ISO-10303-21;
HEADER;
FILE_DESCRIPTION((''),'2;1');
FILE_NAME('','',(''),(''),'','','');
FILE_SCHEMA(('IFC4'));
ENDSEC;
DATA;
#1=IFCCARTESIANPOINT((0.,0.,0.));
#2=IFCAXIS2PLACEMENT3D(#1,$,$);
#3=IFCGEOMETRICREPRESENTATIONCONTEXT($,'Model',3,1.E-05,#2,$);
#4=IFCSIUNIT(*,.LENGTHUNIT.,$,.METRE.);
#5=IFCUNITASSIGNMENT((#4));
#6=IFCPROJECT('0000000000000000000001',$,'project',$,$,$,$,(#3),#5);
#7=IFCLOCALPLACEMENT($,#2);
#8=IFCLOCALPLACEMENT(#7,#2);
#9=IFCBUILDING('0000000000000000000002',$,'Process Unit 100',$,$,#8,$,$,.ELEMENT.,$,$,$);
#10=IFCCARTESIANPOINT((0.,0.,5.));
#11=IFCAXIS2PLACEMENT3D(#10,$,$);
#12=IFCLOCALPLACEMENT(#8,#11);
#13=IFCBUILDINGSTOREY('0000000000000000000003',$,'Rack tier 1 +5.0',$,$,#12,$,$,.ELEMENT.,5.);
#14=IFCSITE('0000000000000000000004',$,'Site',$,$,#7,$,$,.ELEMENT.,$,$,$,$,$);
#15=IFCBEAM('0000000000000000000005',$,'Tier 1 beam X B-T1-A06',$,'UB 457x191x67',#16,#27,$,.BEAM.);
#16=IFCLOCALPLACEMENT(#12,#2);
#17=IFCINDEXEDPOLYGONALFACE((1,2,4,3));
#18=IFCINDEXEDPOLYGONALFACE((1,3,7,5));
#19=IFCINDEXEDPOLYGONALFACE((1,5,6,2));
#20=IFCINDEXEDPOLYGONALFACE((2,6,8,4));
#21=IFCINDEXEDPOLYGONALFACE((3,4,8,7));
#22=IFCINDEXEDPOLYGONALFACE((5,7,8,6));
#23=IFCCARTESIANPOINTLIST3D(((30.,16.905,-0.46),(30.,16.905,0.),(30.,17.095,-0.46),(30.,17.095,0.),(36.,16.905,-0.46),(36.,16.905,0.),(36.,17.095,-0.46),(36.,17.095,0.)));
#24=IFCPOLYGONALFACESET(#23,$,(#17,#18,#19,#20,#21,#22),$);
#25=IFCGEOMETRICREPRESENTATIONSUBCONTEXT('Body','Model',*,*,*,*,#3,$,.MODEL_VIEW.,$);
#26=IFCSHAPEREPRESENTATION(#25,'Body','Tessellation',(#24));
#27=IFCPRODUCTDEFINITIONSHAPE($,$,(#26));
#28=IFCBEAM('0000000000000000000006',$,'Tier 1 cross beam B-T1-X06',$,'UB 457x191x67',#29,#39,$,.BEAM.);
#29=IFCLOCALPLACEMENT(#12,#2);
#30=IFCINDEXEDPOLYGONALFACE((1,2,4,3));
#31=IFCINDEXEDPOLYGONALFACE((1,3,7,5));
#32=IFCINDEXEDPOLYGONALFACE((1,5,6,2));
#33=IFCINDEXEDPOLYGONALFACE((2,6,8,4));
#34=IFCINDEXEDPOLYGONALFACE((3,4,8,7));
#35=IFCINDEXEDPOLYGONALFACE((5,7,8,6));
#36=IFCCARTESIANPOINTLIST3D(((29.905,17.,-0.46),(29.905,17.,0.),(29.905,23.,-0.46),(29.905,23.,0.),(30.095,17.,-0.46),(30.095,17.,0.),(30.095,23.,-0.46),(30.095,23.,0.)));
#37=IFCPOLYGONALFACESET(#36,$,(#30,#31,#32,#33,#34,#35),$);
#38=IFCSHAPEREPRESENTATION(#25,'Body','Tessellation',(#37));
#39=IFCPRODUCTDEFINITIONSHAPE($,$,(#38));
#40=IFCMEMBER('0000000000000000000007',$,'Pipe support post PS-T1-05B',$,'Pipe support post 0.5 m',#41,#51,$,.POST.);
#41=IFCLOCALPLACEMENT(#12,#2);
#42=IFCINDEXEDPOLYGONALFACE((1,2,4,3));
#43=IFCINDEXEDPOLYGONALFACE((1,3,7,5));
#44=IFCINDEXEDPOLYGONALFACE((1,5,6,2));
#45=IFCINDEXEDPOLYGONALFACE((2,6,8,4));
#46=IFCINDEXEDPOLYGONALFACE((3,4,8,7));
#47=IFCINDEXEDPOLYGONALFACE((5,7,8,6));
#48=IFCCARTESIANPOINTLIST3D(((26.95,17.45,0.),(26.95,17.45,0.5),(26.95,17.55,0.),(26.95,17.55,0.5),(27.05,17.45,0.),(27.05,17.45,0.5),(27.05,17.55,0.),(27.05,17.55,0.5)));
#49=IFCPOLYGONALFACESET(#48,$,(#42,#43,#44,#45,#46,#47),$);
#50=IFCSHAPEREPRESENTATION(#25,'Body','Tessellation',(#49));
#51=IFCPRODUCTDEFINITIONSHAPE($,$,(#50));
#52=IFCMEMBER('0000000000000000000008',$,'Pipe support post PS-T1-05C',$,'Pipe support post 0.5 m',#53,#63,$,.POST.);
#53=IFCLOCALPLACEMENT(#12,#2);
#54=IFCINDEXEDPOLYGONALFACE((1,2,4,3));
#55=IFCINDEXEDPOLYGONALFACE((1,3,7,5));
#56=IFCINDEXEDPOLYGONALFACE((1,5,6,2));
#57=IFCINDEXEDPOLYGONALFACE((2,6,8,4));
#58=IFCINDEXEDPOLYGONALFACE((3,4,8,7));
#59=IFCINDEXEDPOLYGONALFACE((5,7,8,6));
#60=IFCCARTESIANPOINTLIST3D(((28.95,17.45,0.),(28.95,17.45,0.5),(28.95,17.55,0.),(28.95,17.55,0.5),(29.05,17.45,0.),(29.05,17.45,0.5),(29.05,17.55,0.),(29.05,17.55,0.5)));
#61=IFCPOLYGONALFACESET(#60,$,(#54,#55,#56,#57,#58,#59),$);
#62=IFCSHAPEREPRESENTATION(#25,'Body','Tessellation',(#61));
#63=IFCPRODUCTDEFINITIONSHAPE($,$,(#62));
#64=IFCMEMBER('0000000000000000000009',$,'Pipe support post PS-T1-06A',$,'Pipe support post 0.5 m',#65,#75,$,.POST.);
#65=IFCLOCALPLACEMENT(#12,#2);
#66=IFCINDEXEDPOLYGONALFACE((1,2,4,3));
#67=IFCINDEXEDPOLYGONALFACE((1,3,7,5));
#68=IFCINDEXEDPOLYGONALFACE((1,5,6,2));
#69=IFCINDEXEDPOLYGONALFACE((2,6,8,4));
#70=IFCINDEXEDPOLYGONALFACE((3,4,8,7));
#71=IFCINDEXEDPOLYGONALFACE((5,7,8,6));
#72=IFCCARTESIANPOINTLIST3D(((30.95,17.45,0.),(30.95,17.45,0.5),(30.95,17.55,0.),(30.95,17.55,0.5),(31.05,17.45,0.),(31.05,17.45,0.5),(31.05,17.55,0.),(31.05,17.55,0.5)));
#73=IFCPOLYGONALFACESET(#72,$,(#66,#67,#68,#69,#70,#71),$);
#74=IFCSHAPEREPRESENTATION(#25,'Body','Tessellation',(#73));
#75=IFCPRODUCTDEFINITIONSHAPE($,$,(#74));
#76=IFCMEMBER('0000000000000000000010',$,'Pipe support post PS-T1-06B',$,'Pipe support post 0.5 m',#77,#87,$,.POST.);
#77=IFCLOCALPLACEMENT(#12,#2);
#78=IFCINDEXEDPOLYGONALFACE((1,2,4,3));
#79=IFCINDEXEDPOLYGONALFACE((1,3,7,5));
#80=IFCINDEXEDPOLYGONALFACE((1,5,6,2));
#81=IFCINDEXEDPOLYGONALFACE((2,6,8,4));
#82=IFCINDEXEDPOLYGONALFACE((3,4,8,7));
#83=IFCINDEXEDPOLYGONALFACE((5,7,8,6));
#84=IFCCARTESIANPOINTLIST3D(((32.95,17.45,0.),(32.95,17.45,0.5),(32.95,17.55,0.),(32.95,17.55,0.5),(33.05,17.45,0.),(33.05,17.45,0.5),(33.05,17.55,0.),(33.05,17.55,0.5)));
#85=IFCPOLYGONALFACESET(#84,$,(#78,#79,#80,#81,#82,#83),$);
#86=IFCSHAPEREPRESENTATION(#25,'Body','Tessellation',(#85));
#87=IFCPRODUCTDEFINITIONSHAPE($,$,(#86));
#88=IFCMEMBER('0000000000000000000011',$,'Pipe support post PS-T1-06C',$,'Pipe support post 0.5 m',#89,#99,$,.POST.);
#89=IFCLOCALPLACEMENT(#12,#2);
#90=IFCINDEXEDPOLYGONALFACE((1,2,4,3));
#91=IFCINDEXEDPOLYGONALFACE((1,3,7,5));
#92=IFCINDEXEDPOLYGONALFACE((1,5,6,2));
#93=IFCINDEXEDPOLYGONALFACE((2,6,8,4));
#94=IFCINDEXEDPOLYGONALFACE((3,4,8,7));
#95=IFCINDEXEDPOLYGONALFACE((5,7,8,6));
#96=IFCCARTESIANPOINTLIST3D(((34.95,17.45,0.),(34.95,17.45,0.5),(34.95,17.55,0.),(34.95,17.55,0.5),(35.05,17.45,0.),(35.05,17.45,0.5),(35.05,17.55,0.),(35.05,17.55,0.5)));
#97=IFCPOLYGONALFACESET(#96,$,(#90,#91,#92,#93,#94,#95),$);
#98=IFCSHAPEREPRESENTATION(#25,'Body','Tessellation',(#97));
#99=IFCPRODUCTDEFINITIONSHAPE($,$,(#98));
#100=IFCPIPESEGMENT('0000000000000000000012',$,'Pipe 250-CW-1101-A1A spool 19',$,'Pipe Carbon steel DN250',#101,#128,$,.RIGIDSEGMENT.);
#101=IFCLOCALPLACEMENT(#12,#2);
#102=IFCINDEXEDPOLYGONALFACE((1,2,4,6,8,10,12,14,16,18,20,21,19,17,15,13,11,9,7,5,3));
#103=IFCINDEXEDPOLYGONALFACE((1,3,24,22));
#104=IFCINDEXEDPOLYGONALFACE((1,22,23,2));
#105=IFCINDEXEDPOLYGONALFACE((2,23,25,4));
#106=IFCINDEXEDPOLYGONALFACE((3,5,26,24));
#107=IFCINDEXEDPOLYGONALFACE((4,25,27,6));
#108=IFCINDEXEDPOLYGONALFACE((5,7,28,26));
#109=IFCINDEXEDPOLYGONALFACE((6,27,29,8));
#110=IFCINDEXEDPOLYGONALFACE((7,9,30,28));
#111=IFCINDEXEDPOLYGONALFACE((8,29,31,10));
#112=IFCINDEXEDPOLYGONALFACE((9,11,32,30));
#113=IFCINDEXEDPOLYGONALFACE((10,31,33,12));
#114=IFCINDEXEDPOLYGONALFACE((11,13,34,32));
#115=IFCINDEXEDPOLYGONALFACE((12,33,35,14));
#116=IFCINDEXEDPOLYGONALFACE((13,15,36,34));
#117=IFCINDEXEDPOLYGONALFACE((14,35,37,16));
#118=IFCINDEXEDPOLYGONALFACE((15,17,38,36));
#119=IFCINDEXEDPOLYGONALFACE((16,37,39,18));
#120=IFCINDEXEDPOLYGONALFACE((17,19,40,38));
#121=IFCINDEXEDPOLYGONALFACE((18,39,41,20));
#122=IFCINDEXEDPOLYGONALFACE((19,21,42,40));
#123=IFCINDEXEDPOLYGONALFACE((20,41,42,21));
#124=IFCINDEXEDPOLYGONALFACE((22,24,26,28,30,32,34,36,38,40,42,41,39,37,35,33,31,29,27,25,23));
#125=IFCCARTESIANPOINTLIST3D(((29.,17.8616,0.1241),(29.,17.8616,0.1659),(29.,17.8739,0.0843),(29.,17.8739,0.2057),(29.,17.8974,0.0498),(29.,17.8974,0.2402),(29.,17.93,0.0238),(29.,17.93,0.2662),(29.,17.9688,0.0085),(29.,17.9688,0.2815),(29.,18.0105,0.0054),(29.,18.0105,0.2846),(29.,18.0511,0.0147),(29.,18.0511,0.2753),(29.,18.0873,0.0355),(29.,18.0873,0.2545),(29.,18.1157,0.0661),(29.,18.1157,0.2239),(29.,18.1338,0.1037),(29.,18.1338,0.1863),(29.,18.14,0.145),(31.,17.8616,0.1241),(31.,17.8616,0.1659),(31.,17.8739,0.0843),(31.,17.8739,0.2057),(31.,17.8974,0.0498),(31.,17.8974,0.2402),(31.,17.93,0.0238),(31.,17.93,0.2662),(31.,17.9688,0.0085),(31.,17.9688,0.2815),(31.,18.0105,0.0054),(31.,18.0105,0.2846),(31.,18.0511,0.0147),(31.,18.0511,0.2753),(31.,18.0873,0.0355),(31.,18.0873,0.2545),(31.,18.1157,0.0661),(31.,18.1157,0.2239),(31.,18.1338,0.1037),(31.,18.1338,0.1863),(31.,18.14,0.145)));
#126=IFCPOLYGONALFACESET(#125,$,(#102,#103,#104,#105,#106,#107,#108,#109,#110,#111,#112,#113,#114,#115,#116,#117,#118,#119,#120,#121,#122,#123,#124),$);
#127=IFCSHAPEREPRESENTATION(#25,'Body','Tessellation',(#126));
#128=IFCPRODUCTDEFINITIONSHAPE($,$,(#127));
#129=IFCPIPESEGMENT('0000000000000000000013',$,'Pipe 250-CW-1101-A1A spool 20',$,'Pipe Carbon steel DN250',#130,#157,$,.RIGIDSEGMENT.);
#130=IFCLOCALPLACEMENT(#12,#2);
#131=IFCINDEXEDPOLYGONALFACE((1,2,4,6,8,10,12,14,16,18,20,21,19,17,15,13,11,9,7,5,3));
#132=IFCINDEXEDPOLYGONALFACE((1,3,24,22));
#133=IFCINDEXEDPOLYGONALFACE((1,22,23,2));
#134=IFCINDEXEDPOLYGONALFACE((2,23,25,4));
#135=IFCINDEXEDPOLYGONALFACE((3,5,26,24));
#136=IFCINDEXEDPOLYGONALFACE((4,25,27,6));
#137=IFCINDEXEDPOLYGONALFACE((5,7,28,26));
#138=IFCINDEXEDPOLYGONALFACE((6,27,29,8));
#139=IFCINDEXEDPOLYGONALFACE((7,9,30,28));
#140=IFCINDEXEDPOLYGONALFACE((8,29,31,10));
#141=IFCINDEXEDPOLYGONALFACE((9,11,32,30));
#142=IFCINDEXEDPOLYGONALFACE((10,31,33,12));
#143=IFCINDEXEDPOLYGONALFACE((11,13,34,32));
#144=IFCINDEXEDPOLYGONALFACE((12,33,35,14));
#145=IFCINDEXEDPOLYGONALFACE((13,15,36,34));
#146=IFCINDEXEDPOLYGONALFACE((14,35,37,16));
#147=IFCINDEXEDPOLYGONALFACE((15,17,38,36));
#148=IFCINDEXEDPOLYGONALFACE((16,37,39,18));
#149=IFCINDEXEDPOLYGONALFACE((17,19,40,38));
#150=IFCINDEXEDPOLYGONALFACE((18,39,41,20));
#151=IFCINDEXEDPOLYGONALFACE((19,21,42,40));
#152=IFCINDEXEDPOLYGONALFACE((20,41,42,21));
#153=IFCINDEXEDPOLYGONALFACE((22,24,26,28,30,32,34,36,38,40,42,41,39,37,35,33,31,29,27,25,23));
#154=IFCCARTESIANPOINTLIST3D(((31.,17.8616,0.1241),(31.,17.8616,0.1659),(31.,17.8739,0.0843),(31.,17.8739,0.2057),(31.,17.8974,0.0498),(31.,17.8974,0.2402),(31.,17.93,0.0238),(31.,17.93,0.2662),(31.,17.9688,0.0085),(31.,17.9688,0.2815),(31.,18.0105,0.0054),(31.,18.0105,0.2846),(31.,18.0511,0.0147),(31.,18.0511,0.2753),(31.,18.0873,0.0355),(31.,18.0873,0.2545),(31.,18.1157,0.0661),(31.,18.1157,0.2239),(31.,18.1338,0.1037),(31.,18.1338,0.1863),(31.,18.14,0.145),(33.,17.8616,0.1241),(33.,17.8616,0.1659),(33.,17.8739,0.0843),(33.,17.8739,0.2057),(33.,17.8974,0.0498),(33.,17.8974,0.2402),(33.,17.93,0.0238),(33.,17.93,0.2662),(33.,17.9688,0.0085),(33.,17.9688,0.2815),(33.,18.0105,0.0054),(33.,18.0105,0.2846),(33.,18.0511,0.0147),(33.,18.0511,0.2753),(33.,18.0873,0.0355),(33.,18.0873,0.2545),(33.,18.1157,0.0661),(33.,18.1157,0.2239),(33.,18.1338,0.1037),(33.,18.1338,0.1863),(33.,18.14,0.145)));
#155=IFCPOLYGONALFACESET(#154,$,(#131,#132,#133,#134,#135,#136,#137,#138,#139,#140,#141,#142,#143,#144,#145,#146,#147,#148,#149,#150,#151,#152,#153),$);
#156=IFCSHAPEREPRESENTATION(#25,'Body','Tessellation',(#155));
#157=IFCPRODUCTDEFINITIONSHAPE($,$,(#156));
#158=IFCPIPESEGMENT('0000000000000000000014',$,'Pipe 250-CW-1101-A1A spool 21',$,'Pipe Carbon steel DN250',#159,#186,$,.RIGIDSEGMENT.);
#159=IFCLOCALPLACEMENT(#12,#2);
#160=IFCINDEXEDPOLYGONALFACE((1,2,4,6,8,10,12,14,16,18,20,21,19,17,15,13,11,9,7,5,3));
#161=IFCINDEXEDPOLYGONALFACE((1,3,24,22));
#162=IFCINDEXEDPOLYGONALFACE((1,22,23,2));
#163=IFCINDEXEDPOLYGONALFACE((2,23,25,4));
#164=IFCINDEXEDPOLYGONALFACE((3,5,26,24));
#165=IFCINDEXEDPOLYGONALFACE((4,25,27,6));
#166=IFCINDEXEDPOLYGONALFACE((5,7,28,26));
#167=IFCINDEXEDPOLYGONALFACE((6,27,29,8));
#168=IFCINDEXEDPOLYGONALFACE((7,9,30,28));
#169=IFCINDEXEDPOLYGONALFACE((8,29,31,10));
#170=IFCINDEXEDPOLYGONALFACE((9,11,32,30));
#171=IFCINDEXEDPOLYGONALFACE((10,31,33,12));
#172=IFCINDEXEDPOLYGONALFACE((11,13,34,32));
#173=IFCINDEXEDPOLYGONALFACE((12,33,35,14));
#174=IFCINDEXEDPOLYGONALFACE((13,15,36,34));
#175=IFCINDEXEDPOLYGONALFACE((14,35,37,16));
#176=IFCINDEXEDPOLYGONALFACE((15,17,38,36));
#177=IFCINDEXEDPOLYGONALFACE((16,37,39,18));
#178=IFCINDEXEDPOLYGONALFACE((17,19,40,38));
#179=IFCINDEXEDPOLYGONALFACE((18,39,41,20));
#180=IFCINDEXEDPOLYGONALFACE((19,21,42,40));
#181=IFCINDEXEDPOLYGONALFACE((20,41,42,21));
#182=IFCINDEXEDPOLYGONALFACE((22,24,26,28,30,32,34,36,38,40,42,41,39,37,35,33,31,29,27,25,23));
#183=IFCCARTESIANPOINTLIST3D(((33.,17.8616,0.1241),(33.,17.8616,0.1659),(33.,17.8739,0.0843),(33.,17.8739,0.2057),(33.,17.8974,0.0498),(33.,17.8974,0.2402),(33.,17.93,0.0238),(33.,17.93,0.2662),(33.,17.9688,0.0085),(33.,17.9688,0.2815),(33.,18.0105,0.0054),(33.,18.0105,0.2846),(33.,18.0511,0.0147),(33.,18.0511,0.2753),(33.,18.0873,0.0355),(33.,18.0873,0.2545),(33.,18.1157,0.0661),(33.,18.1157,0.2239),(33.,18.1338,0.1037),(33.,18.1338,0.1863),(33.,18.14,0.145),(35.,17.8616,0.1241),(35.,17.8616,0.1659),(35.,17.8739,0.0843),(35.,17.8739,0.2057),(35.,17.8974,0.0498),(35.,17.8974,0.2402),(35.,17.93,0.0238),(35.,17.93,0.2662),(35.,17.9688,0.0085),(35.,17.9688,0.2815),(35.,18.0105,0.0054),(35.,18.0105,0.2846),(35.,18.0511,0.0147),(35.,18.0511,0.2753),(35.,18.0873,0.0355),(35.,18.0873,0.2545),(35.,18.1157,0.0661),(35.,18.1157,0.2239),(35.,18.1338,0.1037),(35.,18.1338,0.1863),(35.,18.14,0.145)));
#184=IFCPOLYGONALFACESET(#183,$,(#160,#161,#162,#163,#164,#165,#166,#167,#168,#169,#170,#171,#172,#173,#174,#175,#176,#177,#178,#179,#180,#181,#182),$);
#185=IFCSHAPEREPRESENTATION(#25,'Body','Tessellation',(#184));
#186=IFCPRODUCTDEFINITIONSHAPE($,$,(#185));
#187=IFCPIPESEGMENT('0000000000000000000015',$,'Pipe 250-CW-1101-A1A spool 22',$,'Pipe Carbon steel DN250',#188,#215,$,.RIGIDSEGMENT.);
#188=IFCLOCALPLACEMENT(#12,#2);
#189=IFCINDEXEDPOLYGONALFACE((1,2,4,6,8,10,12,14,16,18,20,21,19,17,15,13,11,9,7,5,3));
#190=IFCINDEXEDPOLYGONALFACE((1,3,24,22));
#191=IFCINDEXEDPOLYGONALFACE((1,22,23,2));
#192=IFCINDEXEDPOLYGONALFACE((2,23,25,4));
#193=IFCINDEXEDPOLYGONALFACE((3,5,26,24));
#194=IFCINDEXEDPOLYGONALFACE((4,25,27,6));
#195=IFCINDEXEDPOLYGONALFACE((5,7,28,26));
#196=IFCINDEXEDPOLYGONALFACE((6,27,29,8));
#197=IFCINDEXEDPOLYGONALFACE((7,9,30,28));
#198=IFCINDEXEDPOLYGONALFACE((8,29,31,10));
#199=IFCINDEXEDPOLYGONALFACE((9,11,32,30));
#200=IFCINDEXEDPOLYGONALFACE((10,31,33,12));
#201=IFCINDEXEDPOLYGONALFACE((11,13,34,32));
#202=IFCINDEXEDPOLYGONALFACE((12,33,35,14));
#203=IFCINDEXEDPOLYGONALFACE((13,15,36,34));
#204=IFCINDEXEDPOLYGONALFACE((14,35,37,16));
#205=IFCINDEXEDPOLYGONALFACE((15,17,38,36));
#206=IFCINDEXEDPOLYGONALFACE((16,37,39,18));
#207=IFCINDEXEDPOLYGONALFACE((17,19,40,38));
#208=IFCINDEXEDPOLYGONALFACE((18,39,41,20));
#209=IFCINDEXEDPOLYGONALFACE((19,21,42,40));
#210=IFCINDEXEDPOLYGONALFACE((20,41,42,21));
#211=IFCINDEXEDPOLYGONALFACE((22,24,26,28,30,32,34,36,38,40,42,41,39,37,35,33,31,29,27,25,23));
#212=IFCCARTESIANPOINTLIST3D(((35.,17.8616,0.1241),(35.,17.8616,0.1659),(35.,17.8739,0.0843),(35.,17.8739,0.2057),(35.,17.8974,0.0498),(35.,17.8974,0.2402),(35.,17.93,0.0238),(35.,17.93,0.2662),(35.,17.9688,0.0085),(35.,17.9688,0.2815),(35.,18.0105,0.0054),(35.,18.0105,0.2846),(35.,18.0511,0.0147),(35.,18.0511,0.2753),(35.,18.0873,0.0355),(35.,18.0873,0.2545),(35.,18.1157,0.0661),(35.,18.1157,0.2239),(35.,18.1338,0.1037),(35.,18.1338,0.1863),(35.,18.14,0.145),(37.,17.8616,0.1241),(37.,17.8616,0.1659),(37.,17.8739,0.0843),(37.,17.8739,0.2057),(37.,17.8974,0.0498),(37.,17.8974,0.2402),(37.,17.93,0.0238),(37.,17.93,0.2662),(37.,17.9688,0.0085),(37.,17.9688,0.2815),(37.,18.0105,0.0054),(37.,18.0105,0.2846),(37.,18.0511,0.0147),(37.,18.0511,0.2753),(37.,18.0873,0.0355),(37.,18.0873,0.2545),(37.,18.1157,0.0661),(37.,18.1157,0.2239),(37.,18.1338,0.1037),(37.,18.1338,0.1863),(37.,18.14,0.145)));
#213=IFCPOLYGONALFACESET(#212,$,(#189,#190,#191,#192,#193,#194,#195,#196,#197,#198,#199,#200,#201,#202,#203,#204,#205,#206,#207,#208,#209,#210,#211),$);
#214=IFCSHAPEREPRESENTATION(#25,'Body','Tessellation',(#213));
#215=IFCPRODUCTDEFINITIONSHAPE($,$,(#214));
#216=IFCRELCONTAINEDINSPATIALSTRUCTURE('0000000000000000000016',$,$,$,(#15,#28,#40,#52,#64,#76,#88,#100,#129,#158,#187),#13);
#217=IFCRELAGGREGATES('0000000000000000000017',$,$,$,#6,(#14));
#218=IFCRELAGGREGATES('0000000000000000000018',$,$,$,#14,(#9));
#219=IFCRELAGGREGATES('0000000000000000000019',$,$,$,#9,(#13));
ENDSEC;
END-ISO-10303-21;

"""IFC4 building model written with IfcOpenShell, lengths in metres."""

from ifc_helpers import new_model, si_unit, frame, origin, place, context, subcontext, project, spatial, rectangle, circle, extrude, element, save


model = new_model("IFC4")

# Units and contexts
model_context = context("Model", 3, precision=1e-05, world=origin())
body_context = subcontext(model_context, "Body", "Model", "MODEL_VIEW")
ifc_project = project(units=[si_unit("LENGTHUNIT", "METRE")], contexts=[model_context])

# Site, building, storey
site_placement = place(None, origin())
site = spatial("IfcSite", under=ifc_project, at=site_placement, Name="Site", CompositionType="ELEMENT")
building_placement = place(site_placement, origin())
building = spatial("IfcBuilding", under=site, at=building_placement, Name="Process Unit 100", CompositionType="ELEMENT")
storey_placement = place(building_placement, frame((0.0, 0.0, 5.0)))
storey = spatial("IfcBuildingStorey", under=building, at=storey_placement, Name="Rack tier 1 +5.0", CompositionType="ELEMENT", Elevation=5.0)

# Beams
for number, where, z_axis, x_axis, name in (
    (1, (30.0, 17.0, -0.23), (1.0, 0.0, 0.0), (0.0, 1.0, 0.0), "Tier 1 beam X B-T1-A06"),
    (2, (30.0, 17.0, -0.23), (0.0, 1.0, 0.0), (-1.0, 0.0, 0.0), "Tier 1 cross beam B-T1-X06"),
):
    element("IfcBeam", number, at=place(storey_placement, frame(where, z_axis=z_axis, x_axis=x_axis)), inside=storey, Name=name, ObjectType="UB 457x191x67", PredefinedType="BEAM", context=body_context, shape_type="SweptSolid", body=[
        extrude(rectangle(XDim=0.19, YDim=0.46), origin(), (0.0, 0.0, 1.0), 6.0),
    ])

# Members
for number, where, z_axis, x_axis, name in (
    (3, (27.0, 17.5, 0.0), (0.0, 0.0, 1.0), (1.0, 0.0, 0.0), "Pipe support post PS-T1-05B"),
    (4, (29.0, 17.5, 0.0), (0.0, 0.0, 1.0), (1.0, 0.0, 0.0), "Pipe support post PS-T1-05C"),
    (5, (31.0, 17.5, 0.0), (0.0, 0.0, 1.0), (1.0, 0.0, 0.0), "Pipe support post PS-T1-06A"),
    (6, (33.0, 17.5, 0.0), (0.0, 0.0, 1.0), (1.0, 0.0, 0.0), "Pipe support post PS-T1-06B"),
    (7, (35.0, 17.5, 0.0), (0.0, 0.0, 1.0), (1.0, 0.0, 0.0), "Pipe support post PS-T1-06C"),
):
    element("IfcMember", number, at=place(storey_placement, frame(where, z_axis=z_axis, x_axis=x_axis)), inside=storey, Name=name, ObjectType="Pipe support post 0.5 m", PredefinedType="POST", context=body_context, shape_type="SweptSolid", body=[
        extrude(rectangle(XDim=0.1, YDim=0.1), origin(), (0.0, 0.0, 1.0), 0.5),
    ])

# Pipe segments
for number, where, z_axis, x_axis, name in (
    (8, (29.0, 18.0, 0.145), (1.0, 0.0, 0.0), (0.0, 1.0, 0.0), "Pipe 250-CW-1101-A1A spool 19"),
    (9, (31.0, 18.0, 0.145), (1.0, 0.0, 0.0), (0.0, 1.0, 0.0), "Pipe 250-CW-1101-A1A spool 20"),
    (10, (33.0, 18.0, 0.145), (1.0, 0.0, 0.0), (0.0, 1.0, 0.0), "Pipe 250-CW-1101-A1A spool 21"),
    (11, (35.0, 18.0, 0.145), (1.0, 0.0, 0.0), (0.0, 1.0, 0.0), "Pipe 250-CW-1101-A1A spool 22"),
):
    element("IfcPipeSegment", number, at=place(storey_placement, frame(where, z_axis=z_axis, x_axis=x_axis)), inside=storey, Name=name, ObjectType="Pipe Carbon steel DN250", PredefinedType="RIGIDSEGMENT", context=body_context, shape_type="SweptSolid", body=[
        extrude(circle(Radius=0.14), origin(), (0.0, 0.0, 1.0), 2.0),
    ])

save(model, "model.ifc")
